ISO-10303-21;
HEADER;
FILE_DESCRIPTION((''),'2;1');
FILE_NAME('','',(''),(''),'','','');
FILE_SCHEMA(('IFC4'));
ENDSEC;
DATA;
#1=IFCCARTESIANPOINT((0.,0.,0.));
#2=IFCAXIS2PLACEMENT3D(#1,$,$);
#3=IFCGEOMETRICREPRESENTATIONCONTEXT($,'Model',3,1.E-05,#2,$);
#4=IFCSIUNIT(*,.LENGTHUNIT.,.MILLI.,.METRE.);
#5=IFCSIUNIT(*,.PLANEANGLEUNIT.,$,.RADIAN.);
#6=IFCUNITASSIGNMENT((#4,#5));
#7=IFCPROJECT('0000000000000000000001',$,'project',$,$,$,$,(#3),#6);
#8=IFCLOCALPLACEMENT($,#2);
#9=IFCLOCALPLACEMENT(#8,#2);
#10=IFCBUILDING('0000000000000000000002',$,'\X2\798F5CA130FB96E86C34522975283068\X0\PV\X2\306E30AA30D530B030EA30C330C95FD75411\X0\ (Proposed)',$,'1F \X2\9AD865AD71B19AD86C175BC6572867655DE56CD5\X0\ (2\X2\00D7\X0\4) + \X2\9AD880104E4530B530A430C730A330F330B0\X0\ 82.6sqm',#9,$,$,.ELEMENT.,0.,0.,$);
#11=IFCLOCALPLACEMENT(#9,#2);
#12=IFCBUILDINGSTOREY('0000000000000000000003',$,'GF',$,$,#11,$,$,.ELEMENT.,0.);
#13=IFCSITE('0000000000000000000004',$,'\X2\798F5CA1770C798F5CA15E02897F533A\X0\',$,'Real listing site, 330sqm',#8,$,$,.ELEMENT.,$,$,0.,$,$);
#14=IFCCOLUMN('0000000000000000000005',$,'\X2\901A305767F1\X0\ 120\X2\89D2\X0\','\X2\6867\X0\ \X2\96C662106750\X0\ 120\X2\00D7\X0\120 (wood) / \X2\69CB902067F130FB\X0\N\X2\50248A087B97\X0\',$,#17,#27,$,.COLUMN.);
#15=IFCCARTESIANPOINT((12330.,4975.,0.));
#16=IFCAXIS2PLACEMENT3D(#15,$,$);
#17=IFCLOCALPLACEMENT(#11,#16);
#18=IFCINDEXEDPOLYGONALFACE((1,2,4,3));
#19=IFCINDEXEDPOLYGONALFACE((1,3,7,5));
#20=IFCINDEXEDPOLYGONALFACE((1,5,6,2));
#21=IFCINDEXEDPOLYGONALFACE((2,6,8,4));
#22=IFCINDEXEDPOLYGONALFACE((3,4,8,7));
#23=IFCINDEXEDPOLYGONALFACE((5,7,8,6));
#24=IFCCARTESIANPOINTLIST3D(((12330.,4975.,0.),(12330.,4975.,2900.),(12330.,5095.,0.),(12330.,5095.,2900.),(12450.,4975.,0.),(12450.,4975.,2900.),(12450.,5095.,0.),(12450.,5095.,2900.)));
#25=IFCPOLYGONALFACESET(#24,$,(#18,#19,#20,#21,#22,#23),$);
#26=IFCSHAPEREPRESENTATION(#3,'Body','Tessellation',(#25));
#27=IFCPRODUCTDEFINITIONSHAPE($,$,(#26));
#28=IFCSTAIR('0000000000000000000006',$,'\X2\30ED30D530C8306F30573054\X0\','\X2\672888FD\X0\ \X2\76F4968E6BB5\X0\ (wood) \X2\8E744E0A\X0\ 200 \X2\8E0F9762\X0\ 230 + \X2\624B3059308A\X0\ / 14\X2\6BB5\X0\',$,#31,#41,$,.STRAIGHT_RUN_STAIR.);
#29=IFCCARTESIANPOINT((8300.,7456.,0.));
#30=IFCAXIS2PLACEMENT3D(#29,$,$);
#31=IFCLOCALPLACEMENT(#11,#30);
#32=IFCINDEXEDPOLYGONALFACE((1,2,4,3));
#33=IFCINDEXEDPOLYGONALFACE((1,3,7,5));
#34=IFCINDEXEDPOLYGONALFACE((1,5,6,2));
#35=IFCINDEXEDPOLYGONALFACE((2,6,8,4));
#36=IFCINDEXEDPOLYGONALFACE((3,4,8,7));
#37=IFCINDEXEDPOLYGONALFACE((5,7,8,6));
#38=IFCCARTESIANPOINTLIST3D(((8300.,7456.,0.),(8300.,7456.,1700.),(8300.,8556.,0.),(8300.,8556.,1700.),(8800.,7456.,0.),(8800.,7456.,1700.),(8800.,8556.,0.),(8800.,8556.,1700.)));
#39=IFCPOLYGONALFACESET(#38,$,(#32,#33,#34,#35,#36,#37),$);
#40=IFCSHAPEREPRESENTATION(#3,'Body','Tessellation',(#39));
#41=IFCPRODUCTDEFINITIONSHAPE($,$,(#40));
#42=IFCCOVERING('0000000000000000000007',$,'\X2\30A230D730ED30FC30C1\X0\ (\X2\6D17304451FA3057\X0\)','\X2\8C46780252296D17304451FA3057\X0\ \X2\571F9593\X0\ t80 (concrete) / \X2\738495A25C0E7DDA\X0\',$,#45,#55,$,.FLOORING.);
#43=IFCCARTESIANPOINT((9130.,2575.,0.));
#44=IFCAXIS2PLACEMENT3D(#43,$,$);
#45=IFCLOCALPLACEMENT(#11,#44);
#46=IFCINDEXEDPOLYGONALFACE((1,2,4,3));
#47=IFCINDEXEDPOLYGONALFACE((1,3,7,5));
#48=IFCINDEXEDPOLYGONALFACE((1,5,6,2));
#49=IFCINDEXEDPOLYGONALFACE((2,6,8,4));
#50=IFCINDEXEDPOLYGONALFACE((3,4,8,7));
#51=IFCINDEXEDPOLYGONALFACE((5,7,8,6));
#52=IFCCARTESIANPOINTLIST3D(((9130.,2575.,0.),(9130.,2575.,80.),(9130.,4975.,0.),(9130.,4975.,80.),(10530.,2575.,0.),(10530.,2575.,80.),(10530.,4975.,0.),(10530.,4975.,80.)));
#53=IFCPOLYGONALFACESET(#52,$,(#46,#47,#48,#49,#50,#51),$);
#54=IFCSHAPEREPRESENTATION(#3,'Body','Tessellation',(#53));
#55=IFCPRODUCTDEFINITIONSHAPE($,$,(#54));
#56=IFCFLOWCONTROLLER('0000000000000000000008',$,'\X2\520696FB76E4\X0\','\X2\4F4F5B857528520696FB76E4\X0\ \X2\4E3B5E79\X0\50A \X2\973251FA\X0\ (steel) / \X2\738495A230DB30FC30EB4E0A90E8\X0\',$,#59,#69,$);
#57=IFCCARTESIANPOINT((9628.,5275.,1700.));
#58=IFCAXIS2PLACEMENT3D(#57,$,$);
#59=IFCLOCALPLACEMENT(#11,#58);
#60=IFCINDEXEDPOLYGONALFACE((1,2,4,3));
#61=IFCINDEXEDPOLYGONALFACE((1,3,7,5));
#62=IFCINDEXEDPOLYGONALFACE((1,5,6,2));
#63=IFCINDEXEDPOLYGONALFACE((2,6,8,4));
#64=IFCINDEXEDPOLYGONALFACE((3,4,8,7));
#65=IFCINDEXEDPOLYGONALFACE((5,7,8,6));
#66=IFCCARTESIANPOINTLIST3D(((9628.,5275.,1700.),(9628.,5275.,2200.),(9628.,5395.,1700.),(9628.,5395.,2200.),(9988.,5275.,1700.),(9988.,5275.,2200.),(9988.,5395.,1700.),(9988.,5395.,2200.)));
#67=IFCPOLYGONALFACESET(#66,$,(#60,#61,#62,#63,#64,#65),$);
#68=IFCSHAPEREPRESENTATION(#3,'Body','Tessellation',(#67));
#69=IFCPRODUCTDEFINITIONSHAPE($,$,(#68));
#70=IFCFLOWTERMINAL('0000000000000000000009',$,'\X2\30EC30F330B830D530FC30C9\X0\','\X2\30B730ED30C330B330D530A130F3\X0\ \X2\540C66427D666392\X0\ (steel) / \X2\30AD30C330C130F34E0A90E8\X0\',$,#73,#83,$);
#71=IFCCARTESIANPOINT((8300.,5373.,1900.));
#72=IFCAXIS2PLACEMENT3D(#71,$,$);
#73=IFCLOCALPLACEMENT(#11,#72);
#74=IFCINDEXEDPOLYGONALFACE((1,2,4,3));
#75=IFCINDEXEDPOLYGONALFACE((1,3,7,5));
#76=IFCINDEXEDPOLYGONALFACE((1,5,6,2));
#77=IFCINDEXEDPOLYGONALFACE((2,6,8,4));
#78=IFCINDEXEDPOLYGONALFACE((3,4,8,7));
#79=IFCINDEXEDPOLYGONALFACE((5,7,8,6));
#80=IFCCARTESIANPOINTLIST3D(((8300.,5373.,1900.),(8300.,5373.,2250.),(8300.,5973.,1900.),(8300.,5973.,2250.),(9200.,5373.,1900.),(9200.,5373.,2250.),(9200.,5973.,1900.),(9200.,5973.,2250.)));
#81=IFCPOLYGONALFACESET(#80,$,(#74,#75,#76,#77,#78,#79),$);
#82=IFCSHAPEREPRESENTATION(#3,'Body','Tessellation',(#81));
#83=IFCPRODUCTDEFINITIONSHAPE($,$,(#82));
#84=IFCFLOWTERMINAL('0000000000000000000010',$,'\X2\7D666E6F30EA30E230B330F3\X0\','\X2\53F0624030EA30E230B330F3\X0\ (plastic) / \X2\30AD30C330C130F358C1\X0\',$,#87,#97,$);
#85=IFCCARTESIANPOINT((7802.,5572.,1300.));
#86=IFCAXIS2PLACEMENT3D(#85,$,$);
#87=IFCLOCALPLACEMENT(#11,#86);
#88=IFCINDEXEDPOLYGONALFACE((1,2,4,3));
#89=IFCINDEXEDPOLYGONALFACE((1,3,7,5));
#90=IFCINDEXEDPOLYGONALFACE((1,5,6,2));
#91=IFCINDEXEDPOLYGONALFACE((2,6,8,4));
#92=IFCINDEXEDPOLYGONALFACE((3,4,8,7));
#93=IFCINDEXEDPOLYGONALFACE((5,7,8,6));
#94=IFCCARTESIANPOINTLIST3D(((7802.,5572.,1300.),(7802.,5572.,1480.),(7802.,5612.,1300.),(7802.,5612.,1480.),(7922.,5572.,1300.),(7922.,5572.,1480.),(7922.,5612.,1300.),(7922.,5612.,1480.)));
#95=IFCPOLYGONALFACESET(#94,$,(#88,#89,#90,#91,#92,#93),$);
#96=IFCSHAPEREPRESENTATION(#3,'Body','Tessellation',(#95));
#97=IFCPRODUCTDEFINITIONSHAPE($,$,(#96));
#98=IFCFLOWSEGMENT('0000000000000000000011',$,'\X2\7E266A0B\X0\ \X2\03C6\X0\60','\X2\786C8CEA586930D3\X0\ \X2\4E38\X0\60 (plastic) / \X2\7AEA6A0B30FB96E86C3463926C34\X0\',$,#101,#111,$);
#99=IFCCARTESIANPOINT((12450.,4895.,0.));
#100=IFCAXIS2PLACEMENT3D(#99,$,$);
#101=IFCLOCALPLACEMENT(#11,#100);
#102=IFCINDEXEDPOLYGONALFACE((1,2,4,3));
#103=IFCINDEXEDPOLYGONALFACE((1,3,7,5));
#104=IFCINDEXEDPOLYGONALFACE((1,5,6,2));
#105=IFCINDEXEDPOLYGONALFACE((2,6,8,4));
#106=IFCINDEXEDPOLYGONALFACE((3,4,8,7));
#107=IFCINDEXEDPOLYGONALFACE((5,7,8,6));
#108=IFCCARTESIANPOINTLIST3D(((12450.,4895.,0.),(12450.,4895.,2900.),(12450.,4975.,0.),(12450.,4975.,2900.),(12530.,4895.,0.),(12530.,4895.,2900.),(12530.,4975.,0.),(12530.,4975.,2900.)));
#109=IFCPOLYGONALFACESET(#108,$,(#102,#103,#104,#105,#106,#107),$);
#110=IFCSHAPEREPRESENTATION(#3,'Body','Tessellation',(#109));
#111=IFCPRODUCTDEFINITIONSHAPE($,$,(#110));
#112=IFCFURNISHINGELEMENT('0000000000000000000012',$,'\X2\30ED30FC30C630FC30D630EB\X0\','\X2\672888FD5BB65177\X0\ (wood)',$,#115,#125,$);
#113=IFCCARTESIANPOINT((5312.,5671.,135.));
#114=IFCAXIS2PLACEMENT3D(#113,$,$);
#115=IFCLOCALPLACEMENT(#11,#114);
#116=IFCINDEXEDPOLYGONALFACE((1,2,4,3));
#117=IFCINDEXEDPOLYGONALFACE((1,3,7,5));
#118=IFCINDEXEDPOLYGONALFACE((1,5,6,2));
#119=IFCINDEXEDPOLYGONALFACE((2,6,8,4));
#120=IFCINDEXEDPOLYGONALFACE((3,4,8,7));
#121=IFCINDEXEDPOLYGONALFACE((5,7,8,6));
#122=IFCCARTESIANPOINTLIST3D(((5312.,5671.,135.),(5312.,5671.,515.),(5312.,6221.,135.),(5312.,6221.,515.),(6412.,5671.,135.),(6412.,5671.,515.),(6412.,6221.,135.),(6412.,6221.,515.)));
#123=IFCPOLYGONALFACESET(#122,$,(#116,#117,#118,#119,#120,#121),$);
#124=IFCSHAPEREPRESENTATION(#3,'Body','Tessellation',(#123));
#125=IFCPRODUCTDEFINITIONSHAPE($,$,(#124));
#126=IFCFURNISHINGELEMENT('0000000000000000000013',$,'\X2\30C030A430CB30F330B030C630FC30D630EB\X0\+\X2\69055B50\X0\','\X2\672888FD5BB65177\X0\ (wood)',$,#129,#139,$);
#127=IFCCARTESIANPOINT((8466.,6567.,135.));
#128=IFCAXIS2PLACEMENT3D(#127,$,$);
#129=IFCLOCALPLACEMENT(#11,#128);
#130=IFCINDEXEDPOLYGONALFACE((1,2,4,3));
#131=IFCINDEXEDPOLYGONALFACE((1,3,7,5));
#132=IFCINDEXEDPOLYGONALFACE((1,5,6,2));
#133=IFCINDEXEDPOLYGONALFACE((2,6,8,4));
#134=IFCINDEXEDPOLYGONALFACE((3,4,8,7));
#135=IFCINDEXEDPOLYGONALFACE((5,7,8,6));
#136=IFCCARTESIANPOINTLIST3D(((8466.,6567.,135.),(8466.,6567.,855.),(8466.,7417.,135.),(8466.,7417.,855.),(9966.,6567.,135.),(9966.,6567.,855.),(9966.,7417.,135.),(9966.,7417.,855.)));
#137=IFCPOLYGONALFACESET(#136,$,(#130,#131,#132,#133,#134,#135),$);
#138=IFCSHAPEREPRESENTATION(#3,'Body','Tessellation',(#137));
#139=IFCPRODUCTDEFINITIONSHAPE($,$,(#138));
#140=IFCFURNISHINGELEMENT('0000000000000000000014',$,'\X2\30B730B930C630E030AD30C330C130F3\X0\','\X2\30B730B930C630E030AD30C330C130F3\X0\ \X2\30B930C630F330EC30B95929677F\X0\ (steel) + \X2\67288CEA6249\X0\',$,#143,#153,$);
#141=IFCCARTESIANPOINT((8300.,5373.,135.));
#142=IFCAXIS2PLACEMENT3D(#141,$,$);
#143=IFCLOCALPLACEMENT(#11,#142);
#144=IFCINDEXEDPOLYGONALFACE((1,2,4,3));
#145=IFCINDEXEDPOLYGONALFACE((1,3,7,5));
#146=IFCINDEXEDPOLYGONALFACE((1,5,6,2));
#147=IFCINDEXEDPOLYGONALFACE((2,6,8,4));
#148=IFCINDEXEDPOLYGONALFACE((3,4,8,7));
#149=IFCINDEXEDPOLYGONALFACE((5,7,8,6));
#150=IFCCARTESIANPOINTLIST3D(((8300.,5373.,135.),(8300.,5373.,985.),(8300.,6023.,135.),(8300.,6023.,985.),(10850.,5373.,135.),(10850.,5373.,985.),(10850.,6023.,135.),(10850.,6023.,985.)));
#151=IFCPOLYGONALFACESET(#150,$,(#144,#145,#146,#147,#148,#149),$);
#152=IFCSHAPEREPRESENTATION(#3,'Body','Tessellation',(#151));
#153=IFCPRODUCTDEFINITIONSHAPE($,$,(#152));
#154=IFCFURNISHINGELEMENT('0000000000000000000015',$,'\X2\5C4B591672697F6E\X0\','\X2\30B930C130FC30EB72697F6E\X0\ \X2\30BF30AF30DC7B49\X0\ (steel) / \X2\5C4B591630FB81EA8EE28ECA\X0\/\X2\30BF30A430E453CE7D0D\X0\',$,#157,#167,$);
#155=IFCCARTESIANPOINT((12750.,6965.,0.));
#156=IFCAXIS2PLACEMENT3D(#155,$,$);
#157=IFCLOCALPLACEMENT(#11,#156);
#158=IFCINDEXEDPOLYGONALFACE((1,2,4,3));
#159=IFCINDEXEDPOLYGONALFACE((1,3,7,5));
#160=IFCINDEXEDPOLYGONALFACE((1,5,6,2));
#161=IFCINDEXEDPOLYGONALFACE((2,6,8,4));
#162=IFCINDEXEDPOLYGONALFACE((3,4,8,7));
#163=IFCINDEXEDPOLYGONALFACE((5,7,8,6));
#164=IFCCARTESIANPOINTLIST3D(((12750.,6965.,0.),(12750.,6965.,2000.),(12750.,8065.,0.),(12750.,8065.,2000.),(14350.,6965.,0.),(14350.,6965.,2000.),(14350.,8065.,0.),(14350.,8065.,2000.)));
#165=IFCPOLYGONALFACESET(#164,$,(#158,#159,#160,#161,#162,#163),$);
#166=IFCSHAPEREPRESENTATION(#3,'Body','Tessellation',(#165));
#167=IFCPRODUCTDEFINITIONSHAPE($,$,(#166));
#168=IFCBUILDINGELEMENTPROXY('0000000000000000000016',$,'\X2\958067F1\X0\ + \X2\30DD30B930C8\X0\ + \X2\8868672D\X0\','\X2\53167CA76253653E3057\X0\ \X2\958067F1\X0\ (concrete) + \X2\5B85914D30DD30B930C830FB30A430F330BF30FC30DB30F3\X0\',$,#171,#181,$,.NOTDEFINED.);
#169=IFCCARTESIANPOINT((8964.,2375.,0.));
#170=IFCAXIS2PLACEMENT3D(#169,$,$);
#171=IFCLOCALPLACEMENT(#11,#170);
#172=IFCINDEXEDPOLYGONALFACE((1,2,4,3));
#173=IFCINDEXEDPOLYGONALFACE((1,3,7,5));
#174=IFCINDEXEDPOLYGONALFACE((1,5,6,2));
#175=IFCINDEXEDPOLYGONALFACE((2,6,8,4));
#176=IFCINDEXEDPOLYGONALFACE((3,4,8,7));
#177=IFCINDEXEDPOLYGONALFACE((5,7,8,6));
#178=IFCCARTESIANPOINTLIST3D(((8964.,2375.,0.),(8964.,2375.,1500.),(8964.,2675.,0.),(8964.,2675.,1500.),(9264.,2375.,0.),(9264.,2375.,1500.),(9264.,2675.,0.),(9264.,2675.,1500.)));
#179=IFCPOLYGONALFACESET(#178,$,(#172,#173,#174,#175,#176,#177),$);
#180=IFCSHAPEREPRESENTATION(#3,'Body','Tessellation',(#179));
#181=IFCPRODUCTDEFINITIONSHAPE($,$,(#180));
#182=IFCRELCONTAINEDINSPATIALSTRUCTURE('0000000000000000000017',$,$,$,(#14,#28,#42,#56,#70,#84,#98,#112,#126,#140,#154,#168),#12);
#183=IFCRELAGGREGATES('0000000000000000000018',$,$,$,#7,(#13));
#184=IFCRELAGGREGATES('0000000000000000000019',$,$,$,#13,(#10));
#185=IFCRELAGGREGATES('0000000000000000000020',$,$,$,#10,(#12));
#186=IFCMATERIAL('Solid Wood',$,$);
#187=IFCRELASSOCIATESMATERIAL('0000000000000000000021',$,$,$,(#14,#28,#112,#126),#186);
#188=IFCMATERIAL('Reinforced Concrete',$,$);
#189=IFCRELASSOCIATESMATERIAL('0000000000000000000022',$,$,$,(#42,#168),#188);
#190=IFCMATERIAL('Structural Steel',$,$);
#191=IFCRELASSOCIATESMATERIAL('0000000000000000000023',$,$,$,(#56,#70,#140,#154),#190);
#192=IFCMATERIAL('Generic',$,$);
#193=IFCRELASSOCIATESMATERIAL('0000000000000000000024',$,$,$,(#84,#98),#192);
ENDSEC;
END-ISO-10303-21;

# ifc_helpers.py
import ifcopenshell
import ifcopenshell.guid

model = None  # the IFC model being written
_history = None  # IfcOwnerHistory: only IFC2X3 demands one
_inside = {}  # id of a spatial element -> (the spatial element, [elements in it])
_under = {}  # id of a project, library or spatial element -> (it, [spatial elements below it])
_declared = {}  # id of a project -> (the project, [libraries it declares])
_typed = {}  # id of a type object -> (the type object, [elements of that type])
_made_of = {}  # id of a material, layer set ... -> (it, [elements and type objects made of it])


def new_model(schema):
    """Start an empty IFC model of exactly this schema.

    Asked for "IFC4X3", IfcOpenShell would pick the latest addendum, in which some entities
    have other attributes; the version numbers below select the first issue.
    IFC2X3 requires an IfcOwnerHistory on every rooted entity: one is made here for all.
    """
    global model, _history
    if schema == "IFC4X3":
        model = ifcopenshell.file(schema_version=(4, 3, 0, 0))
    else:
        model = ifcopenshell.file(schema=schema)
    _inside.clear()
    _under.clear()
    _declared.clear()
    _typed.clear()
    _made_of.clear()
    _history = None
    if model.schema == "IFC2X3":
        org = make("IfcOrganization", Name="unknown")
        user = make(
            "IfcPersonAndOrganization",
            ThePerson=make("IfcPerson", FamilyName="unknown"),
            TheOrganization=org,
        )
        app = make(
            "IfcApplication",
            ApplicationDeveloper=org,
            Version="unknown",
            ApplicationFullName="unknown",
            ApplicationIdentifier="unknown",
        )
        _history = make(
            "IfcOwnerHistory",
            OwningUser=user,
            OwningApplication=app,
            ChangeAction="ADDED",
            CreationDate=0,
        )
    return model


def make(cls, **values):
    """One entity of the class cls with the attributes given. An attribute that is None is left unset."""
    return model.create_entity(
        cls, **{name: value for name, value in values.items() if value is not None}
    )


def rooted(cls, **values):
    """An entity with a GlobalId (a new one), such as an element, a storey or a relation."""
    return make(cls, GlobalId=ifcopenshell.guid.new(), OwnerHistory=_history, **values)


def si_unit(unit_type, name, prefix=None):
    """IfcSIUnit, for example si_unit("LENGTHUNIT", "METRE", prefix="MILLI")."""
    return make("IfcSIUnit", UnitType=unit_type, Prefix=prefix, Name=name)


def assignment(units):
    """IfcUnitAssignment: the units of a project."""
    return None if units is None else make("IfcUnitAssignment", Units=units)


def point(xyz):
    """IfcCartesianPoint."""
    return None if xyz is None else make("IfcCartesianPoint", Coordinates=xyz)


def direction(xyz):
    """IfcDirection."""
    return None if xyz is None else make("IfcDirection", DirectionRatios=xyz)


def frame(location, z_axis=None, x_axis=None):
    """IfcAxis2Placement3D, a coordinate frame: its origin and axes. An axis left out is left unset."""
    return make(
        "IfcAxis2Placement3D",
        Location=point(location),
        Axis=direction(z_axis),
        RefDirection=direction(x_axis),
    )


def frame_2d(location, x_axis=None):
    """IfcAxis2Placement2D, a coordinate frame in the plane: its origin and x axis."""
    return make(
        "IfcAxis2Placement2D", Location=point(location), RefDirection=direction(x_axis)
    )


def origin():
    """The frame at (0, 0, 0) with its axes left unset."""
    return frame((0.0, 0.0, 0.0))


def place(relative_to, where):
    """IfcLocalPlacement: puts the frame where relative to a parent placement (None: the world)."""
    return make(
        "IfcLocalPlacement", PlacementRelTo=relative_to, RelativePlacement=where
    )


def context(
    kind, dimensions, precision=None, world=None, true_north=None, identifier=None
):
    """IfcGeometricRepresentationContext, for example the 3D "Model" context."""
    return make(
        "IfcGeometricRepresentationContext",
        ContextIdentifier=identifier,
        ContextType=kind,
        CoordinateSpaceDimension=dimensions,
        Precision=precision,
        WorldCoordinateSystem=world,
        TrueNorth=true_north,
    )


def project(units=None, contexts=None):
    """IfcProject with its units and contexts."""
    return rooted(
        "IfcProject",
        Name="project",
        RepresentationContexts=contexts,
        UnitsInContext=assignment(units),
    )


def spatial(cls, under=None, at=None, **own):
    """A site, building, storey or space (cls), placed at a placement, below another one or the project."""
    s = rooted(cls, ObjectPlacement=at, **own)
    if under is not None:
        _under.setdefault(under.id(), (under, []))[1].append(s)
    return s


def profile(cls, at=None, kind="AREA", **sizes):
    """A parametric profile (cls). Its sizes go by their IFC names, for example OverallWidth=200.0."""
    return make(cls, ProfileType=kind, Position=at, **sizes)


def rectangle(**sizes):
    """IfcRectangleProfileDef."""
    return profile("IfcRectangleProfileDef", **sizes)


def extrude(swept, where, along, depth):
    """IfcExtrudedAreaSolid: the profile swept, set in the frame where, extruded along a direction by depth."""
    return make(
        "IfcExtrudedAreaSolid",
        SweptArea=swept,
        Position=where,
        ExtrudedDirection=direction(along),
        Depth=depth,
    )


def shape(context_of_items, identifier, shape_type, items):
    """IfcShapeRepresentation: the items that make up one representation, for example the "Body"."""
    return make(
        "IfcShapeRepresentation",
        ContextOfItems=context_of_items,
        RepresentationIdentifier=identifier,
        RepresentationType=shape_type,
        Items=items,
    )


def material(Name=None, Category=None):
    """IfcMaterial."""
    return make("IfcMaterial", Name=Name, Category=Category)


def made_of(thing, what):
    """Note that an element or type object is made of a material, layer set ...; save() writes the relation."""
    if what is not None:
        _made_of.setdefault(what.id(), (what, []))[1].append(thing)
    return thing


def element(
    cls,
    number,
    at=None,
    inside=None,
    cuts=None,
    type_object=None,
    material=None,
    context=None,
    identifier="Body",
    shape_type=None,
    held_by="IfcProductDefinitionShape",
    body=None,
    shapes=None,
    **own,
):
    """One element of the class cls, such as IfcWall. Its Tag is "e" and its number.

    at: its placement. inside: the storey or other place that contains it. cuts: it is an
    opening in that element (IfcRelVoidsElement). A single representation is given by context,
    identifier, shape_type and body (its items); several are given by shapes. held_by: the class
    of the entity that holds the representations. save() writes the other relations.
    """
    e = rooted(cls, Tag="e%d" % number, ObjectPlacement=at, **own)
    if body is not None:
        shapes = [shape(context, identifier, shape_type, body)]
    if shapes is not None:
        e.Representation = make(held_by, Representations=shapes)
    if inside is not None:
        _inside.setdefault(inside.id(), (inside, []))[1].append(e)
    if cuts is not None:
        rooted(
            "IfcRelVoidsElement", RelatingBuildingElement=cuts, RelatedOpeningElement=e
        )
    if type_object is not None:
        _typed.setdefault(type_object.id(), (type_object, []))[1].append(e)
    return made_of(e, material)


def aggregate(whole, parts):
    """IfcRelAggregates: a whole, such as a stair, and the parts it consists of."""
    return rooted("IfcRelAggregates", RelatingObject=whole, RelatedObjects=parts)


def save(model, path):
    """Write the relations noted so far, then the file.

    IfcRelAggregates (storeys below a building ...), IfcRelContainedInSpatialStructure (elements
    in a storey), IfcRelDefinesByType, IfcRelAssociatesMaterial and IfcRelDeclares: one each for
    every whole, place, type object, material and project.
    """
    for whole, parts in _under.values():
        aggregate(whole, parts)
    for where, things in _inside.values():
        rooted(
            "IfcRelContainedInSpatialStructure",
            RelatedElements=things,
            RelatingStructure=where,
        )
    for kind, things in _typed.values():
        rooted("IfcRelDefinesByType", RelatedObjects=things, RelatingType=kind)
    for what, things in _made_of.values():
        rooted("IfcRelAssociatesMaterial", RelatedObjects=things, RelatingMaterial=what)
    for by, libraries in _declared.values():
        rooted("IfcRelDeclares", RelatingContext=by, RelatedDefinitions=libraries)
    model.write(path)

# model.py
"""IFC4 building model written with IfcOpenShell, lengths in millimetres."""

from ifc_helpers import new_model, si_unit, frame, frame_2d, origin, place, context, project, spatial, rectangle, extrude, material, element, save


model = new_model("IFC4")

# Units and contexts
model_context = context("Model", 3, precision=1e-05, world=origin())
ifc_project = project(units=[si_unit("LENGTHUNIT", "METRE", prefix="MILLI"), si_unit("PLANEANGLEUNIT", "RADIAN")], contexts=[model_context])

# Site, building, storey
site_placement = place(None, origin())
site = spatial("IfcSite", under=ifc_project, at=site_placement, Name="福岡県福岡市西区", ObjectType="Real listing site, 330sqm", CompositionType="ELEMENT", RefElevation=0.0)
building_placement = place(site_placement, origin())
building = spatial("IfcBuilding", under=site, at=building_placement, Name="福岡・雨水利用とPVのオフグリッド志向 (Proposed)", ObjectType="1F 高断熱高気密在来工法 (2×4) + 高耐久サイディング 82.6sqm", CompositionType="ELEMENT", ElevationOfRefHeight=0.0, ElevationOfTerrain=0.0)
storey_placement = place(building_placement, origin())
storey = spatial("IfcBuildingStorey", under=building, at=storey_placement, Name="GF", CompositionType="ELEMENT", Elevation=0.0)

# Column
ifc_material_1 = material(Name="Solid Wood")
column_1_placement = place(storey_placement, frame((12330.0, 4975.0, 0.0)))
element("IfcColumn", 1, at=column_1_placement, inside=storey, material=ifc_material_1, Name="通し柱 120角", Description="桧 集成材 120×120 (wood) / 構造柱・N値計算", PredefinedType="COLUMN", context=model_context, shape_type="SweptSolid", body=[
    extrude(rectangle(XDim=120.0, YDim=120.0, at=frame_2d((60.0, 60.0))), frame((12330.0, 4975.0, 0.0)), (0.0, 0.0, 1.0), 2900.0),
])

# Stair
stair_placement = place(storey_placement, frame((8300.0, 7456.0, 0.0)))
element("IfcStair", 2, at=stair_placement, inside=storey, material=ifc_material_1, Name="ロフトはしご", Description="木製 直階段 (wood) 蹴上 200 踏面 230 + 手すり / 14段", PredefinedType="STRAIGHT_RUN_STAIR", context=model_context, shape_type="SweptSolid", body=[
    extrude(rectangle(XDim=500.0, YDim=1100.0, at=frame_2d((250.0, 550.0))), frame((8300.0, 7456.0, 0.0)), (0.0, 0.0, 1.0), 1700.0),
])

# Covering
ifc_material_2 = material(Name="Reinforced Concrete")
covering_placement = place(storey_placement, frame((9130.0, 2575.0, 0.0)))
element("IfcCovering", 3, at=covering_placement, inside=storey, material=ifc_material_2, Name="アプローチ (洗い出し)", Description="豆砂利洗い出し 土間 t80 (concrete) / 玄関導線", PredefinedType="FLOORING", context=model_context, shape_type="SweptSolid", body=[
    extrude(rectangle(XDim=1400.0, YDim=2400.0, at=frame_2d((700.0, 1200.0))), frame((9130.0, 2575.0, 0.0)), (0.0, 0.0, 1.0), 80.0),
])

# Flow controller
ifc_material_3 = material(Name="Structural Steel")
flow_controller_placement = place(storey_placement, frame((9628.0, 5275.0, 1700.0)))
element("IfcFlowController", 4, at=flow_controller_placement, inside=storey, material=ifc_material_3, Name="分電盤", Description="住宅用分電盤 主幹50A 露出 (steel) / 玄関ホール上部", context=model_context, shape_type="SweptSolid", body=[
    extrude(rectangle(XDim=360.0, YDim=120.0, at=frame_2d((180.0, 60.0))), frame((9628.0, 5275.0, 1700.0)), (0.0, 0.0, 1.0), 500.0),
])

# Flow terminals
flow_terminal_1_placement = place(storey_placement, frame((8300.0, 5373.0, 1900.0)))
element("IfcFlowTerminal", 5, at=flow_terminal_1_placement, inside=storey, material=ifc_material_3, Name="レンジフード", Description="シロッコファン 同時給排 (steel) / キッチン上部", context=model_context, shape_type="SweptSolid", body=[
    extrude(rectangle(XDim=900.0, YDim=600.0, at=frame_2d((450.0, 300.0))), frame((8300.0, 5373.0, 1900.0)), (0.0, 0.0, 1.0), 350.0),
])
ifc_material_4 = material(Name="Generic")
flow_terminal_2_placement = place(storey_placement, frame((7802.0, 5572.0, 1300.0)))
element("IfcFlowTerminal", 6, at=flow_terminal_2_placement, inside=storey, material=ifc_material_4, Name="給湯リモコン", Description="台所リモコン (plastic) / キッチン壁", context=model_context, shape_type="SweptSolid", body=[
    extrude(rectangle(XDim=120.0, YDim=40.0, at=frame_2d((60.0, 20.0))), frame((7802.0, 5572.0, 1300.0)), (0.0, 0.0, 1.0), 180.0),
])

# Flow segment
flow_segment_placement = place(storey_placement, frame((12450.0, 4895.0, 0.0)))
element("IfcFlowSegment", 7, at=flow_segment_placement, inside=storey, material=ifc_material_4, Name="縦樋 φ60", Description="硬質塩ビ 丸60 (plastic) / 竪樋・雨水排水", context=model_context, shape_type="SweptSolid", body=[
    extrude(rectangle(XDim=80.0, YDim=80.0, at=frame_2d((40.0, 40.0))), frame((12450.0, 4895.0, 0.0)), (0.0, 0.0, 1.0), 2900.0),
])

# Furnishing elements
furnishing_1_placement = place(storey_placement, frame((5312.0, 5671.0, 135.0)))
element("IfcFurnishingElement", 8, at=furnishing_1_placement, inside=storey, material=ifc_material_1, Name="ローテーブル", Description="木製家具 (wood)", context=model_context, shape_type="SweptSolid", body=[
    extrude(rectangle(XDim=1100.0, YDim=550.0, at=frame_2d((550.0, 275.0))), frame((5312.0, 5671.0, 135.0)), (0.0, 0.0, 1.0), 380.0),
])
furnishing_2_placement = place(storey_placement, frame((8466.0, 6567.0, 135.0)))
element("IfcFurnishingElement", 9, at=furnishing_2_placement, inside=storey, material=ifc_material_1, Name="ダイニングテーブル+椅子", Description="木製家具 (wood)", context=model_context, shape_type="SweptSolid", body=[
    extrude(rectangle(XDim=1500.0, YDim=850.0, at=frame_2d((750.0, 425.0))), frame((8466.0, 6567.0, 135.0)), (0.0, 0.0, 1.0), 720.0),
])
furnishing_3_placement = place(storey_placement, frame((8300.0, 5373.0, 135.0)))
element("IfcFurnishingElement", 10, at=furnishing_3_placement, inside=storey, material=ifc_material_3, Name="システムキッチン", Description="システムキッチン ステンレス天板 (steel) + 木質扉", context=model_context, shape_type="SweptSolid", body=[
    extrude(rectangle(XDim=2550.0, YDim=650.0, at=frame_2d((1275.0, 325.0))), frame((8300.0, 5373.0, 135.0)), (0.0, 0.0, 1.0), 850.0),
])
furnishing_4_placement = place(storey_placement, frame((12750.0, 6965.0, 0.0)))
element("IfcFurnishingElement", 11, at=furnishing_4_placement, inside=storey, material=ifc_material_3, Name="屋外物置", Description="スチール物置 タクボ等 (steel) / 屋外・自転車/タイヤ収納", context=model_context, shape_type="SweptSolid", body=[
    extrude(rectangle(XDim=1600.0, YDim=1100.0, at=frame_2d((800.0, 550.0))), frame((12750.0, 6965.0, 0.0)), (0.0, 0.0, 1.0), 2000.0),
])

# Building element proxy
proxy_placement = place(storey_placement, frame((8964.0, 2375.0, 0.0)))
element("IfcBuildingElementProxy", 12, at=proxy_placement, inside=storey, material=ifc_material_2, Name="門柱 + ポスト + 表札", Description="化粧打放し 門柱 (concrete) + 宅配ポスト・インターホン", PredefinedType="NOTDEFINED", context=model_context, shape_type="SweptSolid", body=[
    extrude(rectangle(XDim=300.0, YDim=300.0, at=frame_2d((150.0, 150.0))), frame((8964.0, 2375.0, 0.0)), (0.0, 0.0, 1.0), 1500.0),
])

save(model, "model.ifc")
